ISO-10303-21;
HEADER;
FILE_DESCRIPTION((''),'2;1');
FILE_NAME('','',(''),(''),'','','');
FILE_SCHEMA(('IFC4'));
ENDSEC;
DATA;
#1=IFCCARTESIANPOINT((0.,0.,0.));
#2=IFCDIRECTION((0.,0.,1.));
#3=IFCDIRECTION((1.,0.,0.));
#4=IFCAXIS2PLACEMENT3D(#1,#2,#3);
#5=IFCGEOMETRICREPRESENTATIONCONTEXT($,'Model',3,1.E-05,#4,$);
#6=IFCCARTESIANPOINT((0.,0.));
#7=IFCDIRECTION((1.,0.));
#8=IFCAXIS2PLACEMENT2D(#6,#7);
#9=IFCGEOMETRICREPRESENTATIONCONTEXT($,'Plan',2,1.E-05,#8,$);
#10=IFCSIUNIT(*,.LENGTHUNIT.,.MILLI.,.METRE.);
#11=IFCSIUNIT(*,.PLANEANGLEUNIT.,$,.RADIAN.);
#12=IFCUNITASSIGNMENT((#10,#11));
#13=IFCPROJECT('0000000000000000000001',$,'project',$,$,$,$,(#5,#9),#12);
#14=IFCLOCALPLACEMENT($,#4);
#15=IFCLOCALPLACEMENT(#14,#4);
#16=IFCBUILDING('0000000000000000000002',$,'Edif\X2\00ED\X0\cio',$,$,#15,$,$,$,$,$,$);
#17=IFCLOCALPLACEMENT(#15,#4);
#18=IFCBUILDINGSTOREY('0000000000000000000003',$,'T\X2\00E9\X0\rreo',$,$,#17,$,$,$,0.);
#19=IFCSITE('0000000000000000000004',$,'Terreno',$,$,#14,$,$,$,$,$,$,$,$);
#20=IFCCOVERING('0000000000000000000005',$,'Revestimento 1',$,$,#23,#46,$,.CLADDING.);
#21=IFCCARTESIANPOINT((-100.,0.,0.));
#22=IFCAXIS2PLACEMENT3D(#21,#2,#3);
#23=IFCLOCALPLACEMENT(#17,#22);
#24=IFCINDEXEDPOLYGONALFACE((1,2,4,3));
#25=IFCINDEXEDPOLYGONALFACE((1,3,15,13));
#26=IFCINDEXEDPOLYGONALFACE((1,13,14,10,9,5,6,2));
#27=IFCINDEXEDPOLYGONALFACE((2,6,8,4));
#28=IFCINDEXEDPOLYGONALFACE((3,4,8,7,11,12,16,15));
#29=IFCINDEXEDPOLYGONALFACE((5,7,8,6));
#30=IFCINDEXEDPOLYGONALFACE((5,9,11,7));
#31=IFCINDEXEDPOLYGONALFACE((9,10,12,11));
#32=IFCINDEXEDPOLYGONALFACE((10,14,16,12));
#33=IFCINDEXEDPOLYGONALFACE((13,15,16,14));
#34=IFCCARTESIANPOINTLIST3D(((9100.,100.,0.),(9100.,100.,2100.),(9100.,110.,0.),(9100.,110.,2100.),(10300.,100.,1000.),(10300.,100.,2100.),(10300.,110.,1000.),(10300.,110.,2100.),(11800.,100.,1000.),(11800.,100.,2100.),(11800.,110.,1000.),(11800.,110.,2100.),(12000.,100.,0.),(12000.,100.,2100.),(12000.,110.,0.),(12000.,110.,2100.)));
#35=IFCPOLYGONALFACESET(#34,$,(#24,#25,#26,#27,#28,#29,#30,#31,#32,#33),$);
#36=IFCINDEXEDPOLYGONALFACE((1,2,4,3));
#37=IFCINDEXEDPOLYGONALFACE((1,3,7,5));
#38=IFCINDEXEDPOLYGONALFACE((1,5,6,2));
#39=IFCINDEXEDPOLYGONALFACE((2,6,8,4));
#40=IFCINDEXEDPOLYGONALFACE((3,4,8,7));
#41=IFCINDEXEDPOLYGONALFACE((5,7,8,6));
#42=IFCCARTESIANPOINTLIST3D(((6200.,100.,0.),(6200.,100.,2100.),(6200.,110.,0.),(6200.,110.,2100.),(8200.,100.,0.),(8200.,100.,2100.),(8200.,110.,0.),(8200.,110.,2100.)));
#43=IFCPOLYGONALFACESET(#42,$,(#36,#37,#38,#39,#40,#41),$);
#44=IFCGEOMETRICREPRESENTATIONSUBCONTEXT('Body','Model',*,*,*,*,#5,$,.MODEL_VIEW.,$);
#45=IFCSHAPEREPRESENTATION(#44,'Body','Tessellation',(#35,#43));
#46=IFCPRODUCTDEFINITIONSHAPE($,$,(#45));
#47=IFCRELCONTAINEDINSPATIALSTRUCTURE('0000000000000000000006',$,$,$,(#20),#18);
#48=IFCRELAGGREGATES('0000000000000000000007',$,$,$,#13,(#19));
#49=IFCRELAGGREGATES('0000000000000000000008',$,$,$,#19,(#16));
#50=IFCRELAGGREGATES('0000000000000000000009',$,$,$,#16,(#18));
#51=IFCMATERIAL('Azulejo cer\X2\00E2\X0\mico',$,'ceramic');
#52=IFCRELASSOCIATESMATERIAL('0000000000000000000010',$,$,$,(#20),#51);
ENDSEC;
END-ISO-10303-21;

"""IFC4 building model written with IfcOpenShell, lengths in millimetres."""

from ifc_helpers import new_model, si_unit, frame, origin_with_axes, origin_2d_with_axis, place, context, subcontext, project, spatial, indexed_curve, outline, extrude, material, element, save


model = new_model("IFC4")

# Units and contexts
model_context = context("Model", 3, precision=1e-05, world=origin_with_axes())
plan_context = context("Plan", 2, precision=1e-05, world=origin_2d_with_axis())
body_context = subcontext(model_context, "Body", "Model", "MODEL_VIEW")
ifc_project = project(units=[si_unit("LENGTHUNIT", "METRE", prefix="MILLI"), si_unit("PLANEANGLEUNIT", "RADIAN")], contexts=[model_context, plan_context])

# Site, building, storey
site_placement = place(None, origin_with_axes())
site = spatial("IfcSite", under=ifc_project, at=site_placement, Name="Terreno")
building_placement = place(site_placement, origin_with_axes())
building = spatial("IfcBuilding", under=site, at=building_placement, Name="Edifício")
storey_placement = place(building_placement, origin_with_axes())
storey = spatial("IfcBuildingStorey", under=building, at=storey_placement, Name="Térreo", Elevation=0.0)

# Covering
ifc_material_1 = material(Name="Azulejo cerâmico", Category="ceramic")
covering_1_placement = place(storey_placement, frame((-100.0, 0.0, 0.0), z_axis=(0.0, 0.0, 1.0), x_axis=(1.0, 0.0, 0.0)))
element("IfcCovering", 1, at=covering_1_placement, inside=storey, material=ifc_material_1, Name="Revestimento 1", PredefinedType="CLADDING", context=body_context, shape_type="SweptSolid", body=[
    extrude(outline(indexed_curve([(9100.0, 0.0), (12000.0, 0.0), (12000.0, 2100.0), (11800.0, 2100.0), (11800.0, 1000.0), (10300.0, 1000.0), (10300.0, 2100.0), (9100.0, 2100.0), (9100.0, 0.0)], self_intersect=False)), frame((0.0, 110.0, 0.0), z_axis=(0.0, -1.0, 0.0), x_axis=(1.0, 0.0, 0.0)), (0.0, 0.0, 1.0), 10.0),
    extrude(outline(indexed_curve([(8200.0, 2100.0), (6200.0, 2100.0), (6200.0, 0.0), (8200.0, 0.0), (8200.0, 2100.0)], self_intersect=False)), frame((0.0, 110.0, 0.0), z_axis=(0.0, -1.0, 0.0), x_axis=(1.0, 0.0, 0.0)), (0.0, 0.0, 1.0), 10.0),
])

save(model, "model.ifc")
